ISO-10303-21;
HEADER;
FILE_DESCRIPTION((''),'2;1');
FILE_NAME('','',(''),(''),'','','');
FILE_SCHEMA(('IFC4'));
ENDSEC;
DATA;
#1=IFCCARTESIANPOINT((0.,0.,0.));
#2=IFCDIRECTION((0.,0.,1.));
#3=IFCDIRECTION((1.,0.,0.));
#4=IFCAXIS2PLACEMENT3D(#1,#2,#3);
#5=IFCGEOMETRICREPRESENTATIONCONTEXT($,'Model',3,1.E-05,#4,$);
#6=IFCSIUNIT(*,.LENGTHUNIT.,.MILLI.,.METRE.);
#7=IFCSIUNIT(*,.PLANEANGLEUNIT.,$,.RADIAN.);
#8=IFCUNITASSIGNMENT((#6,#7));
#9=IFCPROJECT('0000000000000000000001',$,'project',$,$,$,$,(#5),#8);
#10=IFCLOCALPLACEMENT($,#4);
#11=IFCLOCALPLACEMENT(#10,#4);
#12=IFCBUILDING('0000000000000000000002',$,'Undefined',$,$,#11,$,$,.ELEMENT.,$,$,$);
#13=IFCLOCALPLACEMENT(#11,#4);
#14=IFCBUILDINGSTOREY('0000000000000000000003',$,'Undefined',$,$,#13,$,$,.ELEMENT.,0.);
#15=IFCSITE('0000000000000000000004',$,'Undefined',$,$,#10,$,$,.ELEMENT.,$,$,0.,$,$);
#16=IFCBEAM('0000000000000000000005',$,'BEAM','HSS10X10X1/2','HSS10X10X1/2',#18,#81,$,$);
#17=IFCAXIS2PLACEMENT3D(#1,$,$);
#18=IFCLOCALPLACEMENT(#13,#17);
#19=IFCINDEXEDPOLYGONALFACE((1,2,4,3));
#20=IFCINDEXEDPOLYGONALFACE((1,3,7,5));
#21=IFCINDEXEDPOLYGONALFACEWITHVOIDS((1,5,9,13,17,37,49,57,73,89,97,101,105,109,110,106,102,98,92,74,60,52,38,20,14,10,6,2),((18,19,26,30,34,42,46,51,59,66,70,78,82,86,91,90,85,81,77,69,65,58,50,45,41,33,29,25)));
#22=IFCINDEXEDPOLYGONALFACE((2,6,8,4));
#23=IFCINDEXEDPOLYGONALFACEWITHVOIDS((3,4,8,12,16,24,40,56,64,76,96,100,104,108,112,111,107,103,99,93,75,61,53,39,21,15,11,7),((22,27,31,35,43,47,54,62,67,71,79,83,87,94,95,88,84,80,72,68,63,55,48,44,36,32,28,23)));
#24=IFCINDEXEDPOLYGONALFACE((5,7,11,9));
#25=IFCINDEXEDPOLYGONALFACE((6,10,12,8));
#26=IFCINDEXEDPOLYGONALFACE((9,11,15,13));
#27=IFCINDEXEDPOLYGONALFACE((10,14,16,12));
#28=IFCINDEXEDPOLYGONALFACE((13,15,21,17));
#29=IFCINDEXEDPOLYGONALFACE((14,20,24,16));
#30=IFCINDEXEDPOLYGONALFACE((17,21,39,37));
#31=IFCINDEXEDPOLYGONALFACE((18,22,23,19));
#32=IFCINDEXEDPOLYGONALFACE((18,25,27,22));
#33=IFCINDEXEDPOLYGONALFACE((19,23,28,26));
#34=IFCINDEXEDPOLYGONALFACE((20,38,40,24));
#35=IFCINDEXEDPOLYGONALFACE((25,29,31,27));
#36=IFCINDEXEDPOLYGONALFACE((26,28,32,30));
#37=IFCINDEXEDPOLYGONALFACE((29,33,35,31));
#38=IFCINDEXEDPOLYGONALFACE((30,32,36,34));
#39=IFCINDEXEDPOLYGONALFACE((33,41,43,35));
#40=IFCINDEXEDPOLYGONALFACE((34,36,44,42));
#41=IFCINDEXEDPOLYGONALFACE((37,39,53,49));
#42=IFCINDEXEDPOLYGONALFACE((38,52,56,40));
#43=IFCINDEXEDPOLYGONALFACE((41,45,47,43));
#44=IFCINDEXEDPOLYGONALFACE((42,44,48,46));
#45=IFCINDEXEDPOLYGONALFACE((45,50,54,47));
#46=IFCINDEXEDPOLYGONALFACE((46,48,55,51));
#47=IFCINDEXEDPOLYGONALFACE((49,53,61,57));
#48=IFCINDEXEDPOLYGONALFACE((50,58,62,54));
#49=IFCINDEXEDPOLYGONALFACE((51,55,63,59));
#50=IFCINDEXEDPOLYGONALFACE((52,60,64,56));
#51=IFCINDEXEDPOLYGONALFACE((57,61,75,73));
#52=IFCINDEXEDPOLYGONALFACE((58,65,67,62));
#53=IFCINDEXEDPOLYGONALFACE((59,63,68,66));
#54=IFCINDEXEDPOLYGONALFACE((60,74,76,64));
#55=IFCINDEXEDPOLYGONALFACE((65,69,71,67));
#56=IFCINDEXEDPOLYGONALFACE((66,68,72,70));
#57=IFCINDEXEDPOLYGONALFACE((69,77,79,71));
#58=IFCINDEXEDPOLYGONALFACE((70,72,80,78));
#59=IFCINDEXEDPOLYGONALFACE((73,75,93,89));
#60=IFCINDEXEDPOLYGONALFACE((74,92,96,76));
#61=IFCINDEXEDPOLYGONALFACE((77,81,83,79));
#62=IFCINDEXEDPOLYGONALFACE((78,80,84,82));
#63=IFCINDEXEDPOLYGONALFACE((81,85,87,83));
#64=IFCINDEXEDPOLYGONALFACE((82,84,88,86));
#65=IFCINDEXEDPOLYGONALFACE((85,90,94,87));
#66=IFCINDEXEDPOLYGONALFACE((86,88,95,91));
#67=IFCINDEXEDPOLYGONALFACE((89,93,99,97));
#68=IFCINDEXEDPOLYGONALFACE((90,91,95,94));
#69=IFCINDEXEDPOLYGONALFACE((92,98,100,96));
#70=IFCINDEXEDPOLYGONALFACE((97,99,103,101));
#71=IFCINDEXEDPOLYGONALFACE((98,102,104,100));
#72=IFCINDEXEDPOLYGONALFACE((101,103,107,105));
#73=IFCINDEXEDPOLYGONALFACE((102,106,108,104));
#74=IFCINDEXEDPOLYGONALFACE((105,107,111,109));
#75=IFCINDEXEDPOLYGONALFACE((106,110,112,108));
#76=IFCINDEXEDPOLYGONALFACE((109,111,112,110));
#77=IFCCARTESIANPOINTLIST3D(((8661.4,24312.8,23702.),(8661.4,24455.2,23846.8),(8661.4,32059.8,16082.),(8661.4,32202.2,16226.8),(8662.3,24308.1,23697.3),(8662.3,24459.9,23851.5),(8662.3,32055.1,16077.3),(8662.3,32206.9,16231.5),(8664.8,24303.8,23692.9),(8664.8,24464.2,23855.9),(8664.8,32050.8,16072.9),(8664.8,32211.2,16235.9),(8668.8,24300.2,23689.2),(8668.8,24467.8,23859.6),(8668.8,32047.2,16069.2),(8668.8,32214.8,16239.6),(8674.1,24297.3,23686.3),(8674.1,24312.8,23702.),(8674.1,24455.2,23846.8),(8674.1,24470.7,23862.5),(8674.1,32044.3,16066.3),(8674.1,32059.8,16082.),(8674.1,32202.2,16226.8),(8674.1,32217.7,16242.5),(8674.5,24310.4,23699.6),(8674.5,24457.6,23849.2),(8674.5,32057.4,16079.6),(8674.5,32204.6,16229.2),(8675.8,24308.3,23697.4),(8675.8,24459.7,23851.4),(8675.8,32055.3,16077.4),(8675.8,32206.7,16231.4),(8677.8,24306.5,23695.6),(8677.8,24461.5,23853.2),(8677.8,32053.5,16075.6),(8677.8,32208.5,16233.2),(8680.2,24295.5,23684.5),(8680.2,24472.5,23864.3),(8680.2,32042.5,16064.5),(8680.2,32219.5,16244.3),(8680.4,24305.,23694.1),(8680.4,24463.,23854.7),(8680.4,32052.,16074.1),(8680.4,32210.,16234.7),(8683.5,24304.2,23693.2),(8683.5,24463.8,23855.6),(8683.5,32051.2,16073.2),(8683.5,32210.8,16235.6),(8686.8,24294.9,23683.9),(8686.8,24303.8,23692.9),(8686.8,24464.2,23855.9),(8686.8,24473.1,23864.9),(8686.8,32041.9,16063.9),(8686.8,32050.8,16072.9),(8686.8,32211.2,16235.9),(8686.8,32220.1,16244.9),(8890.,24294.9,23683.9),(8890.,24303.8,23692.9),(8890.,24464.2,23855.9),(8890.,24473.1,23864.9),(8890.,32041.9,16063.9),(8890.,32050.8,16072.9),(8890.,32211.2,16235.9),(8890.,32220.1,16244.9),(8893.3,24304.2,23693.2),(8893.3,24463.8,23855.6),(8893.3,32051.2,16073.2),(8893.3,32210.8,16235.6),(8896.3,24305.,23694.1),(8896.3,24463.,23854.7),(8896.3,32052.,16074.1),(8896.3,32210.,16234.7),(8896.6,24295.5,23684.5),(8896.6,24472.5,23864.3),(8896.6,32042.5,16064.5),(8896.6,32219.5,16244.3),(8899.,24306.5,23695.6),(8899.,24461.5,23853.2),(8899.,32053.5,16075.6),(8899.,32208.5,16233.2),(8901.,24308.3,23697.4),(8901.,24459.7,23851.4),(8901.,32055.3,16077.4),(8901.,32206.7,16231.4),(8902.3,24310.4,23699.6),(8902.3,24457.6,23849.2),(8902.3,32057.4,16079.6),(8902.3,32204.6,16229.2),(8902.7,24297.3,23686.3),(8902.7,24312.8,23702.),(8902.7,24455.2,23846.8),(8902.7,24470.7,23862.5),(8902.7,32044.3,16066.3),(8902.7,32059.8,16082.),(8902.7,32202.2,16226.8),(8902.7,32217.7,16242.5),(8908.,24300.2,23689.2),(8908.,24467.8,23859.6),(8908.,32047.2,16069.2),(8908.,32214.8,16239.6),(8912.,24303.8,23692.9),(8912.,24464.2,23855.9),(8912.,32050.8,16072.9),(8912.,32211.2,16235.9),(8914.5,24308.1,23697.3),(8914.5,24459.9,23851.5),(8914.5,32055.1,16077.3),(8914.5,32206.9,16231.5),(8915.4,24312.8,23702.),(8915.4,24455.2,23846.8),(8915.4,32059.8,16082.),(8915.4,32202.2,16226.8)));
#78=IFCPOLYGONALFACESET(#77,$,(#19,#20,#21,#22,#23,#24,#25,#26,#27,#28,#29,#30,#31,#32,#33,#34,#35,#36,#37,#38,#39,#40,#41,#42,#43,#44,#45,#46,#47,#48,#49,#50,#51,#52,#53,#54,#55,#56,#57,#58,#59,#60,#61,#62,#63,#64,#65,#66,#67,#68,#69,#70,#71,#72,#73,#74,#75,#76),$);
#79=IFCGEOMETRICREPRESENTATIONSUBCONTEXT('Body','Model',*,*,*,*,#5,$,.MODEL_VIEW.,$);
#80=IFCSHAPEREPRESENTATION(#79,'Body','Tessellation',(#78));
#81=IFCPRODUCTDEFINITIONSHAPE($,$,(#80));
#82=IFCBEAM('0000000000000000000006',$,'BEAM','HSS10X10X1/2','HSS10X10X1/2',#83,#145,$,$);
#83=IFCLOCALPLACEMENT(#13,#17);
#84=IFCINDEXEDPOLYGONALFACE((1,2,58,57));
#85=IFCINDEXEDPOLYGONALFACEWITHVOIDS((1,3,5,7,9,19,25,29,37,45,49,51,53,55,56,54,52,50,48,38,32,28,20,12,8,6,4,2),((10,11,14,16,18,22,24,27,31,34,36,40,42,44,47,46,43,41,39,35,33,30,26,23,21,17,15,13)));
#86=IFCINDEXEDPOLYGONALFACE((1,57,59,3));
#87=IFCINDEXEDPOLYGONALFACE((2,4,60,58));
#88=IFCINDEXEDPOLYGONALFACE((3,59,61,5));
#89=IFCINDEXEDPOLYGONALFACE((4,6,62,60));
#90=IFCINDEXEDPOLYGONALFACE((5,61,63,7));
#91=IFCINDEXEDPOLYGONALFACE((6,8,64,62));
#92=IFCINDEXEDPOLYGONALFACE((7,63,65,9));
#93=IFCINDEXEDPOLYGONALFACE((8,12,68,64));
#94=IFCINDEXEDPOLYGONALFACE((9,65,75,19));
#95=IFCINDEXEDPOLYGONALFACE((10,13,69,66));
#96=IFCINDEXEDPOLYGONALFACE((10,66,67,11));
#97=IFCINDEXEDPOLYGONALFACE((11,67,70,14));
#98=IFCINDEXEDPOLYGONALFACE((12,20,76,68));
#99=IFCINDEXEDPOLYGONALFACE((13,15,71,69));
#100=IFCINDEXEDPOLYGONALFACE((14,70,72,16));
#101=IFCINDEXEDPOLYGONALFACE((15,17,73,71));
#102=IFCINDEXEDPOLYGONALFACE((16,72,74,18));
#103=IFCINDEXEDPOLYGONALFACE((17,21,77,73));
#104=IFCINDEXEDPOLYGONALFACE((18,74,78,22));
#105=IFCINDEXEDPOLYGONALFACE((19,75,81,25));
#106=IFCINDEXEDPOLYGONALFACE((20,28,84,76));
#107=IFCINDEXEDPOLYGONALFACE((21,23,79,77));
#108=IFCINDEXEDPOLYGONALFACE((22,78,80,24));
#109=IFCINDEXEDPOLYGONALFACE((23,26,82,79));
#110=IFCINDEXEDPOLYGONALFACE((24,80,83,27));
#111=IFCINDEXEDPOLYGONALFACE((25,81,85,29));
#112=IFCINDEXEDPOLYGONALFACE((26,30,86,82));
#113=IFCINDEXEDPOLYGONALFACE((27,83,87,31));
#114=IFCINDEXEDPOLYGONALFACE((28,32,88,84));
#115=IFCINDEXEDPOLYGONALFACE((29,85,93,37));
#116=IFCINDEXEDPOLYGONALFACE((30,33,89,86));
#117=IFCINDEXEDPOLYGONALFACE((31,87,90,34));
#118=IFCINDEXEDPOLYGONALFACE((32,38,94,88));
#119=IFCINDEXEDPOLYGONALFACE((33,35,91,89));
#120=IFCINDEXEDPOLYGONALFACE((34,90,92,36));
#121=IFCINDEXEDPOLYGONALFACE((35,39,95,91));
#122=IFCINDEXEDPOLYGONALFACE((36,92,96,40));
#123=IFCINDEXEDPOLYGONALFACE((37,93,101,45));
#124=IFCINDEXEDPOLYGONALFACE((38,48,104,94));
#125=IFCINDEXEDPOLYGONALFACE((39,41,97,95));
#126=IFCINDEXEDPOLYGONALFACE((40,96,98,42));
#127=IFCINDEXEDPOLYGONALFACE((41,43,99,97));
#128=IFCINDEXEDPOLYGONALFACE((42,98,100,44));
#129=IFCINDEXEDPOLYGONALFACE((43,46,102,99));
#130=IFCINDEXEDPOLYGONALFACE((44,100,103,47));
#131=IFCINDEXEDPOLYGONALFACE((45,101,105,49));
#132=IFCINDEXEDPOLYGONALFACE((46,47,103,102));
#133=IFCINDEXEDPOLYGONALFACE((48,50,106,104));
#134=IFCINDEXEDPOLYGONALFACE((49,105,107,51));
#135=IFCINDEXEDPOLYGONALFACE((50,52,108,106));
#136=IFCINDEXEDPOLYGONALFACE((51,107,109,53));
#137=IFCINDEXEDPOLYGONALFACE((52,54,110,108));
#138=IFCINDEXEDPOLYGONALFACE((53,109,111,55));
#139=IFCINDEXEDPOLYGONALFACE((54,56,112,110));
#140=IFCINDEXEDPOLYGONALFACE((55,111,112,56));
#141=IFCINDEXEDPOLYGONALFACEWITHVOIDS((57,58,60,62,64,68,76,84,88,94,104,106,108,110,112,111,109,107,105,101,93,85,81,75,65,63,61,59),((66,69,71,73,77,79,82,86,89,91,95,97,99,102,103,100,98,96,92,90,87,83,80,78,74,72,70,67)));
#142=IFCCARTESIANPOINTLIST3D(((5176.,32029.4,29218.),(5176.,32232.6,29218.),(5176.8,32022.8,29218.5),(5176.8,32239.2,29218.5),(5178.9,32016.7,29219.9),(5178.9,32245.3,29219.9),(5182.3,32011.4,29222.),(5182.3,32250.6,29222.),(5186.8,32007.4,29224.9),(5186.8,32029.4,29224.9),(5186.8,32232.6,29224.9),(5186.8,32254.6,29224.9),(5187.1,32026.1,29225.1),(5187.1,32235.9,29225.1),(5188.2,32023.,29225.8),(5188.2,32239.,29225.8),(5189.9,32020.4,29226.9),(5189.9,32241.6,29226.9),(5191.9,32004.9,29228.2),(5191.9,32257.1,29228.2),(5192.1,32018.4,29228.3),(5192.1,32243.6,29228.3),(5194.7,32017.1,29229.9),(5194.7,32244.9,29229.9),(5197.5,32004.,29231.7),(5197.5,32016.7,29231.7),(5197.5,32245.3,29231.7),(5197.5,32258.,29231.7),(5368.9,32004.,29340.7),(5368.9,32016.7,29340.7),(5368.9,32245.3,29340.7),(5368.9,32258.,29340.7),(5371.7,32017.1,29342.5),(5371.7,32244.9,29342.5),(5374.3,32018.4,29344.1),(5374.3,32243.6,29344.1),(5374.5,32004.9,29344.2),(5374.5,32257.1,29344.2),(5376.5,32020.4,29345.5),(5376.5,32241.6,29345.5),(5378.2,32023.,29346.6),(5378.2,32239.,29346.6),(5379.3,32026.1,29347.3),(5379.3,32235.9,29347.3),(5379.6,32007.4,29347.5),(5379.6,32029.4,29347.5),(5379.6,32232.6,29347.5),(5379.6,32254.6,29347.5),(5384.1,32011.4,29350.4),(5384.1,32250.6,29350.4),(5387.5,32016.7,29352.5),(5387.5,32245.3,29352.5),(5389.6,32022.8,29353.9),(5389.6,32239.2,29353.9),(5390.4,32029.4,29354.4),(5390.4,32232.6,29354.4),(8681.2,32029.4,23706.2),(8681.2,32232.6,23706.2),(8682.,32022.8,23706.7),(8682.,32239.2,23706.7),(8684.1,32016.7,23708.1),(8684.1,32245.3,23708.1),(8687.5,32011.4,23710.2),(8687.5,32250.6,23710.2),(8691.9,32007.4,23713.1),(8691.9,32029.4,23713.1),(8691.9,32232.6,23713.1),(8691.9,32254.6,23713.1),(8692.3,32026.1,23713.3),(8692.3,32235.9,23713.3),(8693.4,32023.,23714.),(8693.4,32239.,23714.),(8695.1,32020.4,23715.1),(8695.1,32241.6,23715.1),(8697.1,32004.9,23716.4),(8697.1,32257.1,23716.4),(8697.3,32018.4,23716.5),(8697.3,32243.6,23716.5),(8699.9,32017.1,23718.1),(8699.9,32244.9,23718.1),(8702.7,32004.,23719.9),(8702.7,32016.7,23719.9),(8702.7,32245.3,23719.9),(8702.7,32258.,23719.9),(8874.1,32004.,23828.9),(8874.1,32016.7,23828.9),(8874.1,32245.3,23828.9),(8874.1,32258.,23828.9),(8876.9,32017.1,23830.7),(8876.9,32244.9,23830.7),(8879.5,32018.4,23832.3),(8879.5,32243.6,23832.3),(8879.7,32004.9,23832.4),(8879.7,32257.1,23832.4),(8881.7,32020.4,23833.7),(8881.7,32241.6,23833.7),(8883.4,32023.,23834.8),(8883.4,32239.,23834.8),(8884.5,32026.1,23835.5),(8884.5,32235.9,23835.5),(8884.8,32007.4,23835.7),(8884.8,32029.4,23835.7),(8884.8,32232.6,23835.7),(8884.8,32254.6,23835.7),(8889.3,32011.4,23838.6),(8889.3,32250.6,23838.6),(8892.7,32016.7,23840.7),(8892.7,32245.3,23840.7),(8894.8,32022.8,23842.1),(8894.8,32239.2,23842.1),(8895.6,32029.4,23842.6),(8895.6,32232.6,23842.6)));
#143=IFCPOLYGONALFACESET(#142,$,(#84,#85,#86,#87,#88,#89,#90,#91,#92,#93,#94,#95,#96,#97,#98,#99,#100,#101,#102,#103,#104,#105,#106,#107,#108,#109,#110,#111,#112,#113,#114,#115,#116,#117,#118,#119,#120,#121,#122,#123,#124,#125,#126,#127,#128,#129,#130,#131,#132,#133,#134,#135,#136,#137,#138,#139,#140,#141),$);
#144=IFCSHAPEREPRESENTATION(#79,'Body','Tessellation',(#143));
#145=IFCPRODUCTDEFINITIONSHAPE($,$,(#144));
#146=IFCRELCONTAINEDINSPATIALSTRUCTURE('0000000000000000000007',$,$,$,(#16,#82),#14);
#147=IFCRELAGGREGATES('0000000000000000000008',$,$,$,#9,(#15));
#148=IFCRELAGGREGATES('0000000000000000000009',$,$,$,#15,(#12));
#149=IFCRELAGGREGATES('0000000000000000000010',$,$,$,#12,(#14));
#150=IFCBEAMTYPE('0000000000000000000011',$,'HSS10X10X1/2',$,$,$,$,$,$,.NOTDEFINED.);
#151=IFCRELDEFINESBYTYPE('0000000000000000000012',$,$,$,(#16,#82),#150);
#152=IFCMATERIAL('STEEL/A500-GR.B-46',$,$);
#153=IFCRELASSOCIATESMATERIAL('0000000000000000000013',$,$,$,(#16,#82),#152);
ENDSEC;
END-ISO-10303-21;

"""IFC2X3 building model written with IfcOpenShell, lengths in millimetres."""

from ifc_helpers import new_model, si_unit, frame, origin_with_axes, origin_2d_with_axis, place, context, subcontext, project, spatial, hollow_rectangle, extrude, material, type_object, element, save


model = new_model("IFC2X3")

# Units and contexts
model_context = context("Model", 3, precision=1e-05, world=origin_with_axes())
body_context = subcontext(model_context, "Body", "Model", "MODEL_VIEW")
ifc_project = project(units=[si_unit("LENGTHUNIT", "METRE", prefix="MILLI"), si_unit("PLANEANGLEUNIT", "RADIAN")], contexts=[model_context])

# Site, building, storey
site_placement = place(None, origin_with_axes())
site = spatial("IfcSite", under=ifc_project, at=site_placement, Name="Undefined", CompositionType="ELEMENT", RefElevation=0.0)
building_placement = place(site_placement, origin_with_axes())
building = spatial("IfcBuilding", under=site, at=building_placement, Name="Undefined", CompositionType="ELEMENT")
storey_placement = place(building_placement, origin_with_axes())
storey = spatial("IfcBuildingStorey", under=building, at=storey_placement, Name="Undefined", CompositionType="ELEMENT", Elevation=0.0)

# Beams
ifc_material_1 = material(Name="STEEL/A500-GR.B-46")
beam_type_1 = type_object("IfcBeamType", Name="HSS10X10X1/2", PredefinedType="NOTDEFINED")
beam_1_placement = place(storey_placement, frame((8788.4, 32131.0, 16154.4), z_axis=(0.0, 0.701239, 0.712926), x_axis=(0.0, -0.712926, 0.701239)))
element("IfcBeam", 1, at=beam_1_placement, inside=storey, type_object=beam_type_1, material=ifc_material_1, Name="BEAM", Description="HSS10X10X1/2", ObjectType="HSS10X10X1/2", context=body_context, shape_type="SweptSolid", body=[
    extrude(hollow_rectangle(XDim=254.0, YDim=254.0, WallThickness=12.7, InnerFilletRadius=12.7, OuterFilletRadius=25.4, at=origin_2d_with_axis()), frame((10866.5, 0.0, 0.0), z_axis=(-1.0, 0.0, 0.0), x_axis=(0.0, -1.0, 0.0)), (0.0, 0.0, 1.0), 10866.5),
])
beam_2_placement = place(storey_placement, frame((8788.4, 32131.0, 23774.4), z_axis=(0.843822, 0.0, 0.536624), x_axis=(-0.536624, 0.0, 0.843822)))
element("IfcBeam", 2, at=beam_2_placement, inside=storey, type_object=beam_type_1, material=ifc_material_1, Name="BEAM", Description="HSS10X10X1/2", ObjectType="HSS10X10X1/2", context=body_context, shape_type="SweptSolid", body=[
    extrude(hollow_rectangle(XDim=254.0, YDim=254.0, WallThickness=12.7, InnerFilletRadius=12.7, OuterFilletRadius=25.4, at=origin_2d_with_axis()), frame((6531.9, 0.0, 0.0), z_axis=(-1.0, 0.0, 0.0), x_axis=(0.0, -1.0, 0.0)), (0.0, 0.0, 1.0), 6531.9),
])

save(model, "model.ifc")
